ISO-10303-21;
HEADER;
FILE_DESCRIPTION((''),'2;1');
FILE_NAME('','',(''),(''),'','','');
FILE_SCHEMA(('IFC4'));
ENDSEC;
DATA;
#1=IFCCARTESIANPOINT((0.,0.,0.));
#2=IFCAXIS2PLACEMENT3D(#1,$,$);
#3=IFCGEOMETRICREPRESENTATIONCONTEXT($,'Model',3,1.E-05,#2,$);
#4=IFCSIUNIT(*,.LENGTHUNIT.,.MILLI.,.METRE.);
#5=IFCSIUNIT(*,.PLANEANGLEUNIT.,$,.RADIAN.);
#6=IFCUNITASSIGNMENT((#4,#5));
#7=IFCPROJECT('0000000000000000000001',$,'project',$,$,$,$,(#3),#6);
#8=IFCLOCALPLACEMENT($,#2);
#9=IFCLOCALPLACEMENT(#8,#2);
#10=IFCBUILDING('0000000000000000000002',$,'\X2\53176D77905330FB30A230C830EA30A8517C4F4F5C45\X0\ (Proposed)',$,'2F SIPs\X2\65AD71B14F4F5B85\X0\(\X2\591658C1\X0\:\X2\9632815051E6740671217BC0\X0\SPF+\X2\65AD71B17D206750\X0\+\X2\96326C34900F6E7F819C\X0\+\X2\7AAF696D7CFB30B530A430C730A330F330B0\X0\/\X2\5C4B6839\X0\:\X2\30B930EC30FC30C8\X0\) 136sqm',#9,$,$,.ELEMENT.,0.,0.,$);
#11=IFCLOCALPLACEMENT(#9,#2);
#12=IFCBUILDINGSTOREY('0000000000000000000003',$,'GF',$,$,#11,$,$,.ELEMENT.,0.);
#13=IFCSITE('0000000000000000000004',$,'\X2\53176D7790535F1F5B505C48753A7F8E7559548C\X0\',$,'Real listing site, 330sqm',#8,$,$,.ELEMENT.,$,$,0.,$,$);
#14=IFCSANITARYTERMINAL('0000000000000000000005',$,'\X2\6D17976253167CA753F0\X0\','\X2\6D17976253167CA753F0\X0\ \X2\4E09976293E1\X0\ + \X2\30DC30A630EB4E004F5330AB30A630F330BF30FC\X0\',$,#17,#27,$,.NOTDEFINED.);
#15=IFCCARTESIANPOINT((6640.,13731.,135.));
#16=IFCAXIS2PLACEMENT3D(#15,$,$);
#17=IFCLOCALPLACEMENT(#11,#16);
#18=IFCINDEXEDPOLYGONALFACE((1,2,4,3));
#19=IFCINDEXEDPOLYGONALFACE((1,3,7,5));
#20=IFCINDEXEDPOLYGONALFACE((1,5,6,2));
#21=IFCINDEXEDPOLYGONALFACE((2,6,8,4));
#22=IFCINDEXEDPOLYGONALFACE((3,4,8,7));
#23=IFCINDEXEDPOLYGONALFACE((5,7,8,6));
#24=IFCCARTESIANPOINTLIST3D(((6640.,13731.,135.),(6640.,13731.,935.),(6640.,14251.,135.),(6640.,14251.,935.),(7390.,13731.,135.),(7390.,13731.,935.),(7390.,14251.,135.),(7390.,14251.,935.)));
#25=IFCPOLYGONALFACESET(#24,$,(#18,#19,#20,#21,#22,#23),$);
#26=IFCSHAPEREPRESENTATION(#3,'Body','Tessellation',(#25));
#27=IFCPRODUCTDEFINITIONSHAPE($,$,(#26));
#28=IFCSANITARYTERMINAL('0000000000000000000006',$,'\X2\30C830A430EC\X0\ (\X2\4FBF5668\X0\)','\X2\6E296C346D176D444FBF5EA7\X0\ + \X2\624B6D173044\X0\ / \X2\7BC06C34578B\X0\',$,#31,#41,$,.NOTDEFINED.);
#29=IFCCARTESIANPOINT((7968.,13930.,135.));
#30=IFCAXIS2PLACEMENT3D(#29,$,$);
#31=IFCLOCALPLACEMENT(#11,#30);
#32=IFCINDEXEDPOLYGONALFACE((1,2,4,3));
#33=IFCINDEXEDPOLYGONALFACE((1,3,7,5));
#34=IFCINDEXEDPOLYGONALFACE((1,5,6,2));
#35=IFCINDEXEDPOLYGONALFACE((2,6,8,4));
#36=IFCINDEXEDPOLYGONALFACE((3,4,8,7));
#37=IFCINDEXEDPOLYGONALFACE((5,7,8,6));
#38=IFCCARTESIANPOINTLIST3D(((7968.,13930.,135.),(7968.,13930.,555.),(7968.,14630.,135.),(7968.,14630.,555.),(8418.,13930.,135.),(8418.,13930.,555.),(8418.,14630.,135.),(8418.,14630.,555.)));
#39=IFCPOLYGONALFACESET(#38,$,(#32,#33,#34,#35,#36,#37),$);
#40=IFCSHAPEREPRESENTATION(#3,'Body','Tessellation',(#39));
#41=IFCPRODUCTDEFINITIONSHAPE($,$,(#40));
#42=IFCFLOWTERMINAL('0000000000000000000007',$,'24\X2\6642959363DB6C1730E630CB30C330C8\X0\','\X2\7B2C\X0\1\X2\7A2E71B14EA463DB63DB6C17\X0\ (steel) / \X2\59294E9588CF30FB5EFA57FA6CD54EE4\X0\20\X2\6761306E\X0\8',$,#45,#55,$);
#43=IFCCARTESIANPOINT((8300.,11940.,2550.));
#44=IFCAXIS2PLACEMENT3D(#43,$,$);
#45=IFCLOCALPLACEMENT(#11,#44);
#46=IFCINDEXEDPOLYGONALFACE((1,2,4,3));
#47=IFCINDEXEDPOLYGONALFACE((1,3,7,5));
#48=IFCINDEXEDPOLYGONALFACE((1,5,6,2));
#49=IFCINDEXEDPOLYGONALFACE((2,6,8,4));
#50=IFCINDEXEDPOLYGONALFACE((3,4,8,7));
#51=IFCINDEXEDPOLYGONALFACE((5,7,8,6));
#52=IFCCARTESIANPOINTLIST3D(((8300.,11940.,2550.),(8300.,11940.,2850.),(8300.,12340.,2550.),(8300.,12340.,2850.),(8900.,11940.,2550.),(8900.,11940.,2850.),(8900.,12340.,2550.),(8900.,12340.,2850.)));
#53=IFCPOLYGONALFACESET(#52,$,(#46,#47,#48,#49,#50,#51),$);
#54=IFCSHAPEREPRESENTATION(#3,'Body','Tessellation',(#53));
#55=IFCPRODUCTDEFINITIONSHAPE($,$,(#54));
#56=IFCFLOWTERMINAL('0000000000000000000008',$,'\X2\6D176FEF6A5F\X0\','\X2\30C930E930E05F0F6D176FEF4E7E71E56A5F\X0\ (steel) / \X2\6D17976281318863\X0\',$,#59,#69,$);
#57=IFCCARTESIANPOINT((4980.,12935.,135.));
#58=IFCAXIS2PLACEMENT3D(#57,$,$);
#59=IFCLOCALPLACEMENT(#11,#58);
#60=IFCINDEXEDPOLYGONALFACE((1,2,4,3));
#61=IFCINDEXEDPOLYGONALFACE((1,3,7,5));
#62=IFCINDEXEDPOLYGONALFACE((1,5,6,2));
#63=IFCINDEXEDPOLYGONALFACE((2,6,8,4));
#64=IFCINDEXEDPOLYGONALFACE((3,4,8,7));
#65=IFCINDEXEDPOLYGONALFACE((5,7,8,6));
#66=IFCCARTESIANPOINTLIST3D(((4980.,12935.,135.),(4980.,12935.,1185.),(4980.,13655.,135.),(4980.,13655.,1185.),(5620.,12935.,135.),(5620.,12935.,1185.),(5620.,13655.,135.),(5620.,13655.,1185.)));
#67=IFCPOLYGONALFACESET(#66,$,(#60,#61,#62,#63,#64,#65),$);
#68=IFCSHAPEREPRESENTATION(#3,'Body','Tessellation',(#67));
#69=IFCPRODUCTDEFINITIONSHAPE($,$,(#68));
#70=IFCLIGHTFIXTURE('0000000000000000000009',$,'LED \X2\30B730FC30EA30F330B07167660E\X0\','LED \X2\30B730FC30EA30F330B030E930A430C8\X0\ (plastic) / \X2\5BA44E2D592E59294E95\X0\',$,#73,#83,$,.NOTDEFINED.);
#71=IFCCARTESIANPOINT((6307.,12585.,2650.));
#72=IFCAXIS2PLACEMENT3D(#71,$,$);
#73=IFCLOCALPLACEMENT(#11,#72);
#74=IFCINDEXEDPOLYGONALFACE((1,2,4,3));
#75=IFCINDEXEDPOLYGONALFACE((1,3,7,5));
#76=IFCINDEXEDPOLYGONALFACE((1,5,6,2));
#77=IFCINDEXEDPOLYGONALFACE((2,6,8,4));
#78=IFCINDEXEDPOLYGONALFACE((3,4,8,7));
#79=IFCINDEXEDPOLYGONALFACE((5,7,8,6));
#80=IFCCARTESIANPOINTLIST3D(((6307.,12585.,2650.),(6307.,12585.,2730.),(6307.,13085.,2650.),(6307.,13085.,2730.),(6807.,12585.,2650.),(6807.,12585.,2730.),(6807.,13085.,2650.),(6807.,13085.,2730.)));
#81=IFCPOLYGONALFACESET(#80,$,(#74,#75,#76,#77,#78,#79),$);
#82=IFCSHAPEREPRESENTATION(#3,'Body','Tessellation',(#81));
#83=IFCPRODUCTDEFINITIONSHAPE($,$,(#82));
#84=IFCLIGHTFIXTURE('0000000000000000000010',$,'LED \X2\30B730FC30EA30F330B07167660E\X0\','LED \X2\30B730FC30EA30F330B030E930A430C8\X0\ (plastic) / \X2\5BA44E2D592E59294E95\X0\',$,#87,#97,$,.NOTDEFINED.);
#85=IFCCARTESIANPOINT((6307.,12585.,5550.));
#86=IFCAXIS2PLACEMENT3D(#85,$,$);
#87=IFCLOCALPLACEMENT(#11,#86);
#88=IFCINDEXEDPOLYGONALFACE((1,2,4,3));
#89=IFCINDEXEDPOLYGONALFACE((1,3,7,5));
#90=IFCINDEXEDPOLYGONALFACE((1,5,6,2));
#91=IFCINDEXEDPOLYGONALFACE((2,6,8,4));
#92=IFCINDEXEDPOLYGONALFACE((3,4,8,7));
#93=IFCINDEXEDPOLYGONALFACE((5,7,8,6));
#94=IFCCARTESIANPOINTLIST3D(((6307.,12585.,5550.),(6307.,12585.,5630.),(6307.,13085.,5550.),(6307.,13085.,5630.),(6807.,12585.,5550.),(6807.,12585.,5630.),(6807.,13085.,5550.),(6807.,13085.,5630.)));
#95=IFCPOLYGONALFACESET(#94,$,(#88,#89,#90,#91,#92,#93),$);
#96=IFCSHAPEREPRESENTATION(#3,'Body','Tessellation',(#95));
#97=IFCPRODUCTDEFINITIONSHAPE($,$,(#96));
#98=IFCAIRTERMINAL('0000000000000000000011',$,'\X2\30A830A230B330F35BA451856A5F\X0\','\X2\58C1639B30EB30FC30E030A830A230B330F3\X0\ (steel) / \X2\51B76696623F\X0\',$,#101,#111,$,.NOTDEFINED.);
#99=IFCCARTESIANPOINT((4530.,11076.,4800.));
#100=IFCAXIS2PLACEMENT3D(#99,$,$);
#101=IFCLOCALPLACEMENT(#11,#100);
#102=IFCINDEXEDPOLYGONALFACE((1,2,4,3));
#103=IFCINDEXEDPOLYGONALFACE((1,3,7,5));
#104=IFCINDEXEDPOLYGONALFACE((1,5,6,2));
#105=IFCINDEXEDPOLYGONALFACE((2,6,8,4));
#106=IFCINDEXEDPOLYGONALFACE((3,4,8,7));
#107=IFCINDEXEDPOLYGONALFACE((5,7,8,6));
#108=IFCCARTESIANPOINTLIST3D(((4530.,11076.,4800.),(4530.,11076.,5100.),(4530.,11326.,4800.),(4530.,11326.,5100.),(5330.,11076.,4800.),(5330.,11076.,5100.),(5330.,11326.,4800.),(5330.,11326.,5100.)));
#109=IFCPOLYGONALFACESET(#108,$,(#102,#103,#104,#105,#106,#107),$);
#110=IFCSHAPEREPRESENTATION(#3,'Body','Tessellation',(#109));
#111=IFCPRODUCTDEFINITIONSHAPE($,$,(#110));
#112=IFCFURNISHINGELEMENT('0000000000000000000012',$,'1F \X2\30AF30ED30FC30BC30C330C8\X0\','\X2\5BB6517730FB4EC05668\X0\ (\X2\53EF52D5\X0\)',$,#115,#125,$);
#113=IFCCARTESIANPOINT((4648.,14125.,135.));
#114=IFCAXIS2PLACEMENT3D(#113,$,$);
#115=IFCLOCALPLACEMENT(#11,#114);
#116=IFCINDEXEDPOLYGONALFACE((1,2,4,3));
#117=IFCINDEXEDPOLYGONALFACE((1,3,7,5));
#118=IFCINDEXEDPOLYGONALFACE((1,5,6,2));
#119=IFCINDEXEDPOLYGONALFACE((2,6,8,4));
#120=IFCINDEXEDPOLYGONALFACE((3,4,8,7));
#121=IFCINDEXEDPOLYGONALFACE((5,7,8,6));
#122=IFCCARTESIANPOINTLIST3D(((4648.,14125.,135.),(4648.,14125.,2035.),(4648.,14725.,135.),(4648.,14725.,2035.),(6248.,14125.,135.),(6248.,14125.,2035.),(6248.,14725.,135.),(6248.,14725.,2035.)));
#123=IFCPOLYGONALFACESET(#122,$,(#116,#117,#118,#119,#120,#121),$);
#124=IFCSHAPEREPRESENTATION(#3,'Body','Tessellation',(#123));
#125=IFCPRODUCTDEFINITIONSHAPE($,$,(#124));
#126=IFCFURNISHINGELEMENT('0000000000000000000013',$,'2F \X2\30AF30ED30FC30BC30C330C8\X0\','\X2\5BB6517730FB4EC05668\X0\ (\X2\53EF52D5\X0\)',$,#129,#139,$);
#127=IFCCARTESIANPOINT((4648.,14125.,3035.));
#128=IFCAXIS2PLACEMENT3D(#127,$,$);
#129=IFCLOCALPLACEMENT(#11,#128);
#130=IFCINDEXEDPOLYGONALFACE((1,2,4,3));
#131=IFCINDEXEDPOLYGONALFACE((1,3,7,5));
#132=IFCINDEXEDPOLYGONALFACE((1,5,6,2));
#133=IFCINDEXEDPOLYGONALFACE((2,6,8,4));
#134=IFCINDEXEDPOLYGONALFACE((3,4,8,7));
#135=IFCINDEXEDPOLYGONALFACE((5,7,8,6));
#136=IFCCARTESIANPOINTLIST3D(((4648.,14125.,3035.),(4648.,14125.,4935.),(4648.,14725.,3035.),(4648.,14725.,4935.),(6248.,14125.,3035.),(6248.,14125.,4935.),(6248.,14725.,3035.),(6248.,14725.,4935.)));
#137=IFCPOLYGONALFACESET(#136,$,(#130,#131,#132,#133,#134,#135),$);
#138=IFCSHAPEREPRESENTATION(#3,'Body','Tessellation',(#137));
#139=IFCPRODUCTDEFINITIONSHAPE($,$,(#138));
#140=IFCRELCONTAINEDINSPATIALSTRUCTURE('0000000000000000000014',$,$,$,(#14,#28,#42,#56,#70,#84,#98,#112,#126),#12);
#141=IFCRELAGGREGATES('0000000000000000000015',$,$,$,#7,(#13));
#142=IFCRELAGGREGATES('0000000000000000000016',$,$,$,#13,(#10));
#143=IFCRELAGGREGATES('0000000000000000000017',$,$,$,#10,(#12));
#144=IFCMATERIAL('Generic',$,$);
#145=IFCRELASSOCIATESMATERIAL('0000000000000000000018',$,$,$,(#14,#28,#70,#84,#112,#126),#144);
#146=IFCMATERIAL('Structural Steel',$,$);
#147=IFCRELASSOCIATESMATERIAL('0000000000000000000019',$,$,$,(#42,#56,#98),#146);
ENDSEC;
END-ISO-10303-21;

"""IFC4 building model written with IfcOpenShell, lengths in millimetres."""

from ifc_helpers import new_model, si_unit, frame, frame_2d, origin, place, context, project, spatial, rectangle, extrude, material, element, save


model = new_model("IFC4")

# Units and contexts
model_context = context("Model", 3, precision=1e-05, world=origin())
ifc_project = project(units=[si_unit("LENGTHUNIT", "METRE", prefix="MILLI"), si_unit("PLANEANGLEUNIT", "RADIAN")], contexts=[model_context])

# Site, building, storey
site_placement = place(None, origin())
site = spatial("IfcSite", under=ifc_project, at=site_placement, Name="北海道弟子屈町美留和", ObjectType="Real listing site, 330sqm", CompositionType="ELEMENT", RefElevation=0.0)
building_placement = place(site_placement, origin())
building = spatial("IfcBuilding", under=site, at=building_placement, Name="北海道・アトリエ兼住居 (Proposed)", ObjectType="2F SIPs断熱住宅(外壁:防腐処理無節SPF+断熱素材+防水透湿膜+窯業系サイディング/屋根:スレート) 136sqm", CompositionType="ELEMENT", ElevationOfRefHeight=0.0, ElevationOfTerrain=0.0)
storey_placement = place(building_placement, origin())
storey = spatial("IfcBuildingStorey", under=building, at=storey_placement, Name="GF", CompositionType="ELEMENT", Elevation=0.0)

# Sanitary terminals
ifc_material_1 = material(Name="Generic")
sanitary_terminal_1_placement = place(storey_placement, frame((6640.0, 13731.0, 135.0)))
element("IfcSanitaryTerminal", 1, at=sanitary_terminal_1_placement, inside=storey, material=ifc_material_1, Name="洗面化粧台", Description="洗面化粧台 三面鏡 + ボウル一体カウンター", PredefinedType="NOTDEFINED", context=model_context, shape_type="SweptSolid", body=[
    extrude(rectangle(XDim=750.0, YDim=520.0, at=frame_2d((375.0, 260.0))), frame((6640.0, 13731.0, 135.0)), (0.0, 0.0, 1.0), 800.0),
])
sanitary_terminal_2_placement = place(storey_placement, frame((7968.0, 13930.0, 135.0)))
element("IfcSanitaryTerminal", 2, at=sanitary_terminal_2_placement, inside=storey, material=ifc_material_1, Name="トイレ (便器)", Description="温水洗浄便座 + 手洗い / 節水型", PredefinedType="NOTDEFINED", context=model_context, shape_type="SweptSolid", body=[
    extrude(rectangle(XDim=450.0, YDim=700.0, at=frame_2d((225.0, 350.0))), frame((7968.0, 13930.0, 135.0)), (0.0, 0.0, 1.0), 420.0),
])

# Flow terminals
ifc_material_2 = material(Name="Structural Steel")
flow_terminal_1_placement = place(storey_placement, frame((8300.0, 11940.0, 2550.0)))
element("IfcFlowTerminal", 3, at=flow_terminal_1_placement, inside=storey, material=ifc_material_2, Name="24時間換気ユニット", Description="第1種熱交換換気 (steel) / 天井裏・建基法令20条の8", context=model_context, shape_type="SweptSolid", body=[
    extrude(rectangle(XDim=600.0, YDim=400.0, at=frame_2d((300.0, 200.0))), frame((8300.0, 11940.0, 2550.0)), (0.0, 0.0, 1.0), 300.0),
])
flow_terminal_2_placement = place(storey_placement, frame((4980.0, 12935.0, 135.0)))
element("IfcFlowTerminal", 4, at=flow_terminal_2_placement, inside=storey, material=ifc_material_2, Name="洗濯機", Description="ドラム式洗濯乾燥機 (steel) / 洗面脱衣", context=model_context, shape_type="SweptSolid", body=[
    extrude(rectangle(XDim=640.0, YDim=720.0, at=frame_2d((320.0, 360.0))), frame((4980.0, 12935.0, 135.0)), (0.0, 0.0, 1.0), 1050.0),
])

# Light fixtures
light_fixture_1_placement = place(storey_placement, frame((6307.0, 12585.0, 2650.0)))
element("IfcLightFixture", 5, at=light_fixture_1_placement, inside=storey, material=ifc_material_1, Name="LED シーリング照明", Description="LED シーリングライト (plastic) / 室中央天井", PredefinedType="NOTDEFINED", context=model_context, shape_type="SweptSolid", body=[
    extrude(rectangle(XDim=500.0, YDim=500.0, at=frame_2d((250.0, 250.0))), frame((6307.0, 12585.0, 2650.0)), (0.0, 0.0, 1.0), 80.0),
])
light_fixture_2_placement = place(storey_placement, frame((6307.0, 12585.0, 5550.0)))
element("IfcLightFixture", 6, at=light_fixture_2_placement, inside=storey, material=ifc_material_1, Name="LED シーリング照明", Description="LED シーリングライト (plastic) / 室中央天井", PredefinedType="NOTDEFINED", context=model_context, shape_type="SweptSolid", body=[
    extrude(rectangle(XDim=500.0, YDim=500.0, at=frame_2d((250.0, 250.0))), frame((6307.0, 12585.0, 5550.0)), (0.0, 0.0, 1.0), 80.0),
])

# Air terminal
air_terminal_placement = place(storey_placement, frame((4530.0, 11076.0, 4800.0)))
element("IfcAirTerminal", 7, at=air_terminal_placement, inside=storey, material=ifc_material_2, Name="エアコン室内機", Description="壁掛ルームエアコン (steel) / 冷暖房", PredefinedType="NOTDEFINED", context=model_context, shape_type="SweptSolid", body=[
    extrude(rectangle(XDim=800.0, YDim=250.0, at=frame_2d((400.0, 125.0))), frame((4530.0, 11076.0, 4800.0)), (0.0, 0.0, 1.0), 300.0),
])

# Furnishing elements
furnishing_1_placement = place(storey_placement, frame((4648.0, 14125.0, 135.0)))
element("IfcFurnishingElement", 8, at=furnishing_1_placement, inside=storey, material=ifc_material_1, Name="1F クローゼット", Description="家具・什器 (可動)", context=model_context, shape_type="SweptSolid", body=[
    extrude(rectangle(XDim=1600.0, YDim=600.0, at=frame_2d((800.0, 300.0))), frame((4648.0, 14125.0, 135.0)), (0.0, 0.0, 1.0), 1900.0),
])
furnishing_2_placement = place(storey_placement, frame((4648.0, 14125.0, 3035.0)))
element("IfcFurnishingElement", 9, at=furnishing_2_placement, inside=storey, material=ifc_material_1, Name="2F クローゼット", Description="家具・什器 (可動)", context=model_context, shape_type="SweptSolid", body=[
    extrude(rectangle(XDim=1600.0, YDim=600.0, at=frame_2d((800.0, 300.0))), frame((4648.0, 14125.0, 3035.0)), (0.0, 0.0, 1.0), 1900.0),
])

save(model, "model.ifc")
